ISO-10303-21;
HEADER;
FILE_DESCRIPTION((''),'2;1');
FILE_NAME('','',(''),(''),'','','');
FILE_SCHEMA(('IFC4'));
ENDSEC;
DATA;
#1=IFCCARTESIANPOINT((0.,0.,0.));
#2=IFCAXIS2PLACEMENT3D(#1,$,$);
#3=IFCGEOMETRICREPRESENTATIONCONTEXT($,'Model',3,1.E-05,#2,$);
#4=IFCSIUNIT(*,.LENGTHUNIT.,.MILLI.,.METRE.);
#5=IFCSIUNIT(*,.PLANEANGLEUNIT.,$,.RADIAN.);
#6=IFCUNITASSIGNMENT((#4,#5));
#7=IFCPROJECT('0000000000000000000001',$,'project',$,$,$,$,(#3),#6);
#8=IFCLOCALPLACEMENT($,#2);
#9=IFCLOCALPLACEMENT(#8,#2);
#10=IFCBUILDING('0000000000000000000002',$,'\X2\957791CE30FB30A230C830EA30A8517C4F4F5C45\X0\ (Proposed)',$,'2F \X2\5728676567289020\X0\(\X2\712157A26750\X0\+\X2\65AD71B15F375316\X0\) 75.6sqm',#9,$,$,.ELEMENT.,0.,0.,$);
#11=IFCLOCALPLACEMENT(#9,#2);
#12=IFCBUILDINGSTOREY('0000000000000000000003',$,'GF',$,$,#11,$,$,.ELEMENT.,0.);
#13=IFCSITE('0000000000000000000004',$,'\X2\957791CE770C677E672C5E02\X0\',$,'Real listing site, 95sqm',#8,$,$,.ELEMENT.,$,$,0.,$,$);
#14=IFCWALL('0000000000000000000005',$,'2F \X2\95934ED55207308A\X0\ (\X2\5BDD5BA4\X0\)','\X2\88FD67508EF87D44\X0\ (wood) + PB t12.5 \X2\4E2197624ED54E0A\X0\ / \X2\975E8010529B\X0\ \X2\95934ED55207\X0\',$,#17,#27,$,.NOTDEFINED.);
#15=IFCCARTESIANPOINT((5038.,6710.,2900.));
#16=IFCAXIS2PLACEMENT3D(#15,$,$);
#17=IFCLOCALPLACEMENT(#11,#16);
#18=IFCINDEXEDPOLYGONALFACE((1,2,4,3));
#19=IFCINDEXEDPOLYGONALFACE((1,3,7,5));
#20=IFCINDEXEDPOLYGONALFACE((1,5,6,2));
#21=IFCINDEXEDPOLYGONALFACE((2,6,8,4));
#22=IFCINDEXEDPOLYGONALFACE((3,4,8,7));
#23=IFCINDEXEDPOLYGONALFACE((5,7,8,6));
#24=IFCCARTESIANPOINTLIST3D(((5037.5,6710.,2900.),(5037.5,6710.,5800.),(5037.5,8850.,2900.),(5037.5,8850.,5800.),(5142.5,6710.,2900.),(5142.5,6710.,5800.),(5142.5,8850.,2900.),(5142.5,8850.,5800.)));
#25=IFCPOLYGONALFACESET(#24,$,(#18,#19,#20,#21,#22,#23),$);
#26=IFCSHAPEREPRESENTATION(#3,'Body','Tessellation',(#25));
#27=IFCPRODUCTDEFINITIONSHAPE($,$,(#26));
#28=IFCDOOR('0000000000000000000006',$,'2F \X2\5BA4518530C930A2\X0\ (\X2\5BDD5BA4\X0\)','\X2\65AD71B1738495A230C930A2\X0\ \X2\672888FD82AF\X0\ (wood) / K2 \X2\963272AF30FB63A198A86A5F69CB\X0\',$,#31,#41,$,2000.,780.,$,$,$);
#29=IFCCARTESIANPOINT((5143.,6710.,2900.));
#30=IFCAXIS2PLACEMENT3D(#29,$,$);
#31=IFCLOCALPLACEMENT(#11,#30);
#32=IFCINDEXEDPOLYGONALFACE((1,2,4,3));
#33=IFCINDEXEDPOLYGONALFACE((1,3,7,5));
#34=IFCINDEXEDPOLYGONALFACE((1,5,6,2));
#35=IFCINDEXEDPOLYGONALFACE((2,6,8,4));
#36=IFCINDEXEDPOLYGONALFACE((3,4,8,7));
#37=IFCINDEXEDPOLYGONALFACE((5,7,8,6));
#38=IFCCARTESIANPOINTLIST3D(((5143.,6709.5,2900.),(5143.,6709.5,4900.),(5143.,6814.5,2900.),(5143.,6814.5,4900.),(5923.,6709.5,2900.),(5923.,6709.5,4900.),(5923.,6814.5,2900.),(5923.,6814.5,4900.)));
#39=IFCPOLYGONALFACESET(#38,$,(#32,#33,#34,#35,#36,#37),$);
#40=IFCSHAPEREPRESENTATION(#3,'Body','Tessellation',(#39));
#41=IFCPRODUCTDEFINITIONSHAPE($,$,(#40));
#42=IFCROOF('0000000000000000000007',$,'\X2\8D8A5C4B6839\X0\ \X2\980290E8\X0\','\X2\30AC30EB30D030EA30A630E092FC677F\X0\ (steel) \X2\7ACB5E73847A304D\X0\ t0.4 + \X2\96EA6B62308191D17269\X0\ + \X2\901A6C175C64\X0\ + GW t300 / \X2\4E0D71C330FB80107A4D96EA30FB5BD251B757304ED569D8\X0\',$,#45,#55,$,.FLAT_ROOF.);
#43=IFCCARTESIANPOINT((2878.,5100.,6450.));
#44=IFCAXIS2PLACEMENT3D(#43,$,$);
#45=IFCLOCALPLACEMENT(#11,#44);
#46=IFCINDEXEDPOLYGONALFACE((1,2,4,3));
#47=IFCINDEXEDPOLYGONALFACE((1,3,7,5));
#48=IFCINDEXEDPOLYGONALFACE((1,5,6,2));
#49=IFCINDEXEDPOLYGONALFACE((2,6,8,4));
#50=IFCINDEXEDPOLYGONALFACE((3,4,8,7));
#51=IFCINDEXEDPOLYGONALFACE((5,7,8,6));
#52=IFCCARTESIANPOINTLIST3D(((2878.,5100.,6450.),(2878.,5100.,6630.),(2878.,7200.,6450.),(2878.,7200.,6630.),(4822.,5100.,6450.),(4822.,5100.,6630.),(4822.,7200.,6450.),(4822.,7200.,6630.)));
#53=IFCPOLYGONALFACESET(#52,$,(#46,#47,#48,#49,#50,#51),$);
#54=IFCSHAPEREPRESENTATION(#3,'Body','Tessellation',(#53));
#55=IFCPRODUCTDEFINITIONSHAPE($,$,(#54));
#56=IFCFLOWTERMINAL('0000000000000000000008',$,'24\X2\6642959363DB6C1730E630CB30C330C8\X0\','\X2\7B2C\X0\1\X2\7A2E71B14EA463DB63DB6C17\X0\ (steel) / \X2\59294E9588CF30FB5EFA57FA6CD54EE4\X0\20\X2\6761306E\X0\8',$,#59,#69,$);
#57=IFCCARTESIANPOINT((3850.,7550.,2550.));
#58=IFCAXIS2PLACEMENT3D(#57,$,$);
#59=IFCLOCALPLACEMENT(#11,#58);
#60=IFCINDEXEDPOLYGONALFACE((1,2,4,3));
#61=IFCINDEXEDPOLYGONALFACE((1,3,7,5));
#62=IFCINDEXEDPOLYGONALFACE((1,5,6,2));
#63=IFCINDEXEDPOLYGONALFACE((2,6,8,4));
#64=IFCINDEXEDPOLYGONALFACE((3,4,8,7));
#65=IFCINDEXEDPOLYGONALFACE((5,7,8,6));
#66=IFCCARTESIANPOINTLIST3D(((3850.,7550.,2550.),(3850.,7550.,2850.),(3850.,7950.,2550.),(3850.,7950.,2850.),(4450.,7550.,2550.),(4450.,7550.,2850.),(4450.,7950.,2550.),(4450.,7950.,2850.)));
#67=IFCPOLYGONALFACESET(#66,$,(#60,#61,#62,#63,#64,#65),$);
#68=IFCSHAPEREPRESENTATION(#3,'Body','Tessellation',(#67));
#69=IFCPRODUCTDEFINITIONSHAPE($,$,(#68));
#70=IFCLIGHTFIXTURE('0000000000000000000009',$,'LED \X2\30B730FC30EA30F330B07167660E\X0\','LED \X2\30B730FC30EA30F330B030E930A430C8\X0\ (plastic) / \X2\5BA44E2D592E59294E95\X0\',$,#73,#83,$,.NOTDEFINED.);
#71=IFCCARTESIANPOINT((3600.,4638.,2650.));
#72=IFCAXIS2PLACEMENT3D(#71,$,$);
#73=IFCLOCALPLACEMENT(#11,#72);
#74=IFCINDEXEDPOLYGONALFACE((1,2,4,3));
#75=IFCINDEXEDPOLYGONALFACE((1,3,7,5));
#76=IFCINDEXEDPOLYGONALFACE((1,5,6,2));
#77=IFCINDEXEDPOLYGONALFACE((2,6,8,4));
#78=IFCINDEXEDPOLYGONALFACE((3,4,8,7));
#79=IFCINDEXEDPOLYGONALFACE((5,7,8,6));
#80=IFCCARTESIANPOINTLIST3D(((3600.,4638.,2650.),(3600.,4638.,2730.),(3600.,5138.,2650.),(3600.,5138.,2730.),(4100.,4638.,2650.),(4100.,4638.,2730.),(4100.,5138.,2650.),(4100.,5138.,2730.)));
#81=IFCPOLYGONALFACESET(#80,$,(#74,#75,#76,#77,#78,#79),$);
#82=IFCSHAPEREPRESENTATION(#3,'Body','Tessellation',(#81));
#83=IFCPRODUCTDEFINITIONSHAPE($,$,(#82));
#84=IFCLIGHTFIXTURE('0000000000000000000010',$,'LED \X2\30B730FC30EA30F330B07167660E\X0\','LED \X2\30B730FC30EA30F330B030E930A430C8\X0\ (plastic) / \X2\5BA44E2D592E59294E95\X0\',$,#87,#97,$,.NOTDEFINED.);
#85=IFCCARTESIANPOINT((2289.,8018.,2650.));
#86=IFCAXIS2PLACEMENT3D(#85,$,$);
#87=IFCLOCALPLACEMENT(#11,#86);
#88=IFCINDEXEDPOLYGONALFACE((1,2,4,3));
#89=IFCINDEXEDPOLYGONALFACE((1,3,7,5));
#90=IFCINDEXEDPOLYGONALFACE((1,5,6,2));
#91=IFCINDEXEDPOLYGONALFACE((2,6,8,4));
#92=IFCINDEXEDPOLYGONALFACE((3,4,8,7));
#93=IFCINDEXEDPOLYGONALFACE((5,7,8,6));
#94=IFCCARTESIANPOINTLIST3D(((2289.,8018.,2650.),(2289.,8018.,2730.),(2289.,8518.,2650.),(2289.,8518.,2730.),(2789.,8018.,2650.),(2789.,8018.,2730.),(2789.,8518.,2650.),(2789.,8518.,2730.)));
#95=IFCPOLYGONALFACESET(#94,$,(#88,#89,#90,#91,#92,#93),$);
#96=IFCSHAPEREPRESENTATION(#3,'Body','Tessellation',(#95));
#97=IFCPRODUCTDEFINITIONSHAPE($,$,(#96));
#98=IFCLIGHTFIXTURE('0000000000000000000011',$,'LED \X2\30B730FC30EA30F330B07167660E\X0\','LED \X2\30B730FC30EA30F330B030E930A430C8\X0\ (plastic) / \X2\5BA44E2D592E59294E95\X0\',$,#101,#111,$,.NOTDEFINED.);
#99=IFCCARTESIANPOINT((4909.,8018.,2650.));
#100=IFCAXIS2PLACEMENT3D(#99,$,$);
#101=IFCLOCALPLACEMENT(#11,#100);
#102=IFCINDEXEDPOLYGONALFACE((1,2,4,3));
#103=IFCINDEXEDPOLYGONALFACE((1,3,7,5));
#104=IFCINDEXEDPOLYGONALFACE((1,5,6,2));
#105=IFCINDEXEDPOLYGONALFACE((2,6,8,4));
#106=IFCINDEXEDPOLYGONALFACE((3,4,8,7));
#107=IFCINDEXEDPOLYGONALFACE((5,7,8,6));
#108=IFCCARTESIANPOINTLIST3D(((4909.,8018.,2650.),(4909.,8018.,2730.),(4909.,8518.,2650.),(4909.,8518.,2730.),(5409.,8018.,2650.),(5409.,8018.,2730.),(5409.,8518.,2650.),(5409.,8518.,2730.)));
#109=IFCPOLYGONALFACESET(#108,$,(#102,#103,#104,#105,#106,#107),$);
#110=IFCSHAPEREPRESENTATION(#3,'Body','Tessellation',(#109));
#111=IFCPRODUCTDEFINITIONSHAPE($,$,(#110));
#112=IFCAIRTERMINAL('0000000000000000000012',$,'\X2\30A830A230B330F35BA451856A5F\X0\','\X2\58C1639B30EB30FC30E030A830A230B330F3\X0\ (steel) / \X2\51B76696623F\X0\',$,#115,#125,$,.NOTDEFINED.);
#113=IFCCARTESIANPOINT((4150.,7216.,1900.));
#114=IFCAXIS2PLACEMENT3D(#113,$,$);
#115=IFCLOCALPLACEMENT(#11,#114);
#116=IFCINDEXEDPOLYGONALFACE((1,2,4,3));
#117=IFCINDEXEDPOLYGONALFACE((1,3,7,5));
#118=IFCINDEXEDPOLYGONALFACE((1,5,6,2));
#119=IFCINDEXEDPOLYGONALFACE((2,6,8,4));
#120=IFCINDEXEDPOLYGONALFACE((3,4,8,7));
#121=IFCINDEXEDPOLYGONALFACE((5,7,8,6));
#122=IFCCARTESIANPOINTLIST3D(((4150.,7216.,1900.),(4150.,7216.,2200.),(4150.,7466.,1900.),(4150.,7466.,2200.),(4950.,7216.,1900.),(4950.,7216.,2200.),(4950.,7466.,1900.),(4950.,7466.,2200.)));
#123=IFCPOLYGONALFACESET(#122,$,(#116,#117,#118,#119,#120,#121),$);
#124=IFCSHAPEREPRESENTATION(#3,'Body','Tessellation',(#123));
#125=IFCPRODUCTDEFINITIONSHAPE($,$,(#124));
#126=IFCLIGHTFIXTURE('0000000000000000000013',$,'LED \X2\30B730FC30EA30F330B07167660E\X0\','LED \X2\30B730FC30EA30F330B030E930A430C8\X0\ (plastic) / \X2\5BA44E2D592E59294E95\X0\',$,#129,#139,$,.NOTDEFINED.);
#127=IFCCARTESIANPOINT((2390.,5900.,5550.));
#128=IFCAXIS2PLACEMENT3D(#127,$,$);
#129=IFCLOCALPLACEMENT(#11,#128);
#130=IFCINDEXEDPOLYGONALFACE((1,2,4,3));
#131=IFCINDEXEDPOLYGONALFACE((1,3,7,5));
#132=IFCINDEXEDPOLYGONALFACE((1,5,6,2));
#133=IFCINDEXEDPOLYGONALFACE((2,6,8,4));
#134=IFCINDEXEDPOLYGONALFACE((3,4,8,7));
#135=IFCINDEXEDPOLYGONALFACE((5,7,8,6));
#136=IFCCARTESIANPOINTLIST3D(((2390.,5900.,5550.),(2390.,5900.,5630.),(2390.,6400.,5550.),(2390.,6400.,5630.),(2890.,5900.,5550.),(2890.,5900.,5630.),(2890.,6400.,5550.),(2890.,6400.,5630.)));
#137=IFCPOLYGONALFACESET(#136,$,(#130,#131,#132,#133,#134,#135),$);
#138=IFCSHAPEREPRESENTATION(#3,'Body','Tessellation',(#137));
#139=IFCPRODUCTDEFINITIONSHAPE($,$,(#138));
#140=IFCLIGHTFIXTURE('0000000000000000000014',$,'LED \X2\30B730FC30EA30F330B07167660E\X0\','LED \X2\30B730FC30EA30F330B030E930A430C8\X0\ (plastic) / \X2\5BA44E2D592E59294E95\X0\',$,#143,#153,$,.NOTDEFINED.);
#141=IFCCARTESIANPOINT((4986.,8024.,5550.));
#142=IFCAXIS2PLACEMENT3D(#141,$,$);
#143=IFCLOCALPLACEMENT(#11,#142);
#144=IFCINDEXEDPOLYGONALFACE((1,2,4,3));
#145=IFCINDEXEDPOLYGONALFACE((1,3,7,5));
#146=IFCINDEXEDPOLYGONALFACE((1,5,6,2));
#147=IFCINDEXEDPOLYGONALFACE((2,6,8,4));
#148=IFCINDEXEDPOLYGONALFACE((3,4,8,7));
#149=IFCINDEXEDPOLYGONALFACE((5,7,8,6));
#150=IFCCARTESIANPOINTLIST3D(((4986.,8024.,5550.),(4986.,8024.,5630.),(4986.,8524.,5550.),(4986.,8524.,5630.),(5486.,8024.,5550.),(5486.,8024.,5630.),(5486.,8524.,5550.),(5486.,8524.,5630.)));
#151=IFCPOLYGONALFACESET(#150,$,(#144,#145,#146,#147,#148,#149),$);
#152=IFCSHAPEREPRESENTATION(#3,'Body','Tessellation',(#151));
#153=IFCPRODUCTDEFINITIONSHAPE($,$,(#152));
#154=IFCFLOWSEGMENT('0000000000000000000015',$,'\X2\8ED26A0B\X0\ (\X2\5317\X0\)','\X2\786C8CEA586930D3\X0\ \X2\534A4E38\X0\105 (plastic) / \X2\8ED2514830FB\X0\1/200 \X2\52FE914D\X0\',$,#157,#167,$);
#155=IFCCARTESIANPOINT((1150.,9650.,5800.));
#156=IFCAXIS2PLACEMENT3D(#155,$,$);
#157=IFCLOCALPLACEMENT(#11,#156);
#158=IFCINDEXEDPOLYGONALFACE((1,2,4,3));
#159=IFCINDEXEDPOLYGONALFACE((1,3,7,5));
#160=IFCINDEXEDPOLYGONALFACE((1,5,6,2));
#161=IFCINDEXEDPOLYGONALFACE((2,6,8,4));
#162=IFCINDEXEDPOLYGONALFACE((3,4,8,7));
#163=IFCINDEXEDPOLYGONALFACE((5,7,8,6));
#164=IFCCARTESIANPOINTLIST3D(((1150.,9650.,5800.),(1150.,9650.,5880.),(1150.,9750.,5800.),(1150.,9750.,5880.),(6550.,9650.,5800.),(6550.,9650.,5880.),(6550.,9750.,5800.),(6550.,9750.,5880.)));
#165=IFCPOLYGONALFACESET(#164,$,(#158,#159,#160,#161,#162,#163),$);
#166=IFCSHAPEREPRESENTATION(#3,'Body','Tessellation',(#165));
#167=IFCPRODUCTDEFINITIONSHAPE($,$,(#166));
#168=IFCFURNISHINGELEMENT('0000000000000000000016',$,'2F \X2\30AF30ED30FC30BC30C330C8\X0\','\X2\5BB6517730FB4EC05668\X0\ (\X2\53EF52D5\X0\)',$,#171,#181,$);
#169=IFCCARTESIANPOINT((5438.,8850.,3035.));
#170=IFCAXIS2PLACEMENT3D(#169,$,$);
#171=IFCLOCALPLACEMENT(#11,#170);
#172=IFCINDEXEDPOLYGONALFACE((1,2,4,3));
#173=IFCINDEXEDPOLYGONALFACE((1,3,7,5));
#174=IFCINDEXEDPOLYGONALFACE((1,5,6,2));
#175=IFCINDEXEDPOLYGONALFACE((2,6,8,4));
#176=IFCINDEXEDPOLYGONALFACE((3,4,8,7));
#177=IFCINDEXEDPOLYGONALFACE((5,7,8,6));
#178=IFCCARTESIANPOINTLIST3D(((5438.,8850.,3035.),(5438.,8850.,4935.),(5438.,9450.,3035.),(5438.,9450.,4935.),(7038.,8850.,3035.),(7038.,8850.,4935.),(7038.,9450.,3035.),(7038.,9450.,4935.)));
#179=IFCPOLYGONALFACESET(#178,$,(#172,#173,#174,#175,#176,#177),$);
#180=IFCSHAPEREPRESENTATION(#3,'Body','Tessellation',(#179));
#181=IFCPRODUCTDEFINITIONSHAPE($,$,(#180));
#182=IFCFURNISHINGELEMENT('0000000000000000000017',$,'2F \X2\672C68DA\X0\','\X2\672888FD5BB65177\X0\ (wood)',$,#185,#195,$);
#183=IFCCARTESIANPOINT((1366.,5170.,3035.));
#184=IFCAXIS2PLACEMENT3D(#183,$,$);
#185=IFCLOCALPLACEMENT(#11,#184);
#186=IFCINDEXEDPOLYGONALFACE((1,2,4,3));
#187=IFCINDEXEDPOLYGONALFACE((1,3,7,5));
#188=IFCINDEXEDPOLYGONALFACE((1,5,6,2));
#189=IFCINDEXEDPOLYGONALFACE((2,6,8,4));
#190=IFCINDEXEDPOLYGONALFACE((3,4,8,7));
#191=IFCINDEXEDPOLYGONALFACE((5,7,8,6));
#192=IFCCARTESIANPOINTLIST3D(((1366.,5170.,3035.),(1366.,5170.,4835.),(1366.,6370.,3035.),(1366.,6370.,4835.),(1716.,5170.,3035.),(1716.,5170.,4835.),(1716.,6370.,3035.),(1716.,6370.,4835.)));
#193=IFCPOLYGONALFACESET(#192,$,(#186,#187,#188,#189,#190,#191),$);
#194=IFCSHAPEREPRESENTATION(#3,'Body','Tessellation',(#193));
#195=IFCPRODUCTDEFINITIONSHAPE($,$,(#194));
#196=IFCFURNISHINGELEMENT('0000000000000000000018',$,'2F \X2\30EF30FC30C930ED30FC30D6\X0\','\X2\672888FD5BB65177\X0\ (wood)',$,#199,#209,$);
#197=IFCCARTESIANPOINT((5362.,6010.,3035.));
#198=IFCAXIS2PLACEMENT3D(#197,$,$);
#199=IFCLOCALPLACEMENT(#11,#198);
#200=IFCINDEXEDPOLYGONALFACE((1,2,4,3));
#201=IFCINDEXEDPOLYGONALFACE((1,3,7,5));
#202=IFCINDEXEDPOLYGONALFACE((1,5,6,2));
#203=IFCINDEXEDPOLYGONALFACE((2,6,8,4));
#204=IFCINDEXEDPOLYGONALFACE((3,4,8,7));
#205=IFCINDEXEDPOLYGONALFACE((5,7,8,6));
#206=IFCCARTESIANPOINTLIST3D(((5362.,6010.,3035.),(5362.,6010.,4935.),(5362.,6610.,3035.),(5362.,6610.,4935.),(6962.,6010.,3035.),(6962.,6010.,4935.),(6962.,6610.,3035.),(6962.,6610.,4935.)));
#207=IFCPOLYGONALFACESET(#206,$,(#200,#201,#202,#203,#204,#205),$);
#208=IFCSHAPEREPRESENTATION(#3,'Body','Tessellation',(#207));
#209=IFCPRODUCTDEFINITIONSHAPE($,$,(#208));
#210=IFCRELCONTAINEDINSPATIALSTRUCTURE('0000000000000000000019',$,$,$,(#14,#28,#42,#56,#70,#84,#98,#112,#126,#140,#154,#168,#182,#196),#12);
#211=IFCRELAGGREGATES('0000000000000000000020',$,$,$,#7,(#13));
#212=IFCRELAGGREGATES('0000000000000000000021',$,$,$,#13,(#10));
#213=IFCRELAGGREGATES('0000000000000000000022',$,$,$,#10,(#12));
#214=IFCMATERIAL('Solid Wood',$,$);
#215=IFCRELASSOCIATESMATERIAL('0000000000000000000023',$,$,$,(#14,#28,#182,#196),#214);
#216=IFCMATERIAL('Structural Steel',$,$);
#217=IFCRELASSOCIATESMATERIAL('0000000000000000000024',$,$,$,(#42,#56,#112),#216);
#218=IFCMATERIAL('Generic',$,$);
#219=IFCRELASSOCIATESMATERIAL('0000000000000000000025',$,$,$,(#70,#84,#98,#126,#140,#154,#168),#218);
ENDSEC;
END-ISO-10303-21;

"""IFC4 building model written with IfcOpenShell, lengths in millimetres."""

from ifc_helpers import new_model, si_unit, frame, frame_2d, origin, place, context, project, spatial, rectangle, extrude, material, element, save


model = new_model("IFC4")

# Units and contexts
model_context = context("Model", 3, precision=1e-05, world=origin())
ifc_project = project(units=[si_unit("LENGTHUNIT", "METRE", prefix="MILLI"), si_unit("PLANEANGLEUNIT", "RADIAN")], contexts=[model_context])

# Site, building, storey
site_placement = place(None, origin())
site = spatial("IfcSite", under=ifc_project, at=site_placement, Name="長野県松本市", ObjectType="Real listing site, 95sqm", CompositionType="ELEMENT", RefElevation=0.0)
building_placement = place(site_placement, origin())
building = spatial("IfcBuilding", under=site, at=building_placement, Name="長野・アトリエ兼住居 (Proposed)", ObjectType="2F 在来木造(無垢材+断熱強化) 75.6sqm", CompositionType="ELEMENT", ElevationOfRefHeight=0.0, ElevationOfTerrain=0.0)
storey_placement = place(building_placement, origin())
storey = spatial("IfcBuildingStorey", under=building, at=storey_placement, Name="GF", CompositionType="ELEMENT", Elevation=0.0)

# Shared definitions
ifc_material_1 = material(Name="Solid Wood")

# Wall
wall_1_placement = place(storey_placement, frame((5038.0, 6710.0, 2900.0)))
element("IfcWall", 1, at=wall_1_placement, inside=storey, material=ifc_material_1, Name="2F 間仕切り (寝室)", Description="製材軸組 (wood) + PB t12.5 両面仕上 / 非耐力 間仕切", PredefinedType="NOTDEFINED", context=model_context, shape_type="SweptSolid", body=[
    extrude(rectangle(XDim=105.0, YDim=2140.0, at=frame_2d((52.0, 1070.0))), frame((5038.0, 6710.0, 2900.0)), (0.0, 0.0, 1.0), 2900.0),
])

# Door
door_placement = place(storey_placement, frame((5143.0, 6710.0, 2900.0)))
element("IfcDoor", 2, at=door_placement, inside=storey, material=ifc_material_1, Name="2F 室内ドア (寝室)", Description="断熱玄関ドア 木製芯 (wood) / K2 防犯・採風機構", OverallHeight=2000.0, OverallWidth=780.0, context=model_context, shape_type="SweptSolid", body=[
    extrude(rectangle(XDim=780.0, YDim=105.0, at=frame_2d((390.0, 52.0))), frame((5143.0, 6710.0, 2900.0)), (0.0, 0.0, 1.0), 2000.0),
])

# Roof
ifc_material_2 = material(Name="Structural Steel")
roof_placement = place(storey_placement, frame((2878.0, 5100.0, 6450.0)))
element("IfcRoof", 3, at=roof_placement, inside=storey, material=ifc_material_2, Name="越屋根 頂部", Description="ガルバリウム鋼板 (steel) 立平葺き t0.4 + 雪止め金物 + 通気層 + GW t300 / 不燃・耐積雪・寒冷地仕様", PredefinedType="FLAT_ROOF", context=model_context, shape_type="SweptSolid", body=[
    extrude(rectangle(XDim=1944.0, YDim=2100.0, at=frame_2d((972.0, 1050.0))), frame((2878.0, 5100.0, 6450.0)), (0.0, 0.0, 1.0), 180.0),
])

# Flow terminal
flow_terminal_placement = place(storey_placement, frame((3850.0, 7550.0, 2550.0)))
element("IfcFlowTerminal", 4, at=flow_terminal_placement, inside=storey, material=ifc_material_2, Name="24時間換気ユニット", Description="第1種熱交換換気 (steel) / 天井裏・建基法令20条の8", context=model_context, shape_type="SweptSolid", body=[
    extrude(rectangle(XDim=600.0, YDim=400.0, at=frame_2d((300.0, 200.0))), frame((3850.0, 7550.0, 2550.0)), (0.0, 0.0, 1.0), 300.0),
])

# Light fixtures
ifc_material_3 = material(Name="Generic")
light_fixture_1_placement = place(storey_placement, frame((3600.0, 4638.0, 2650.0)))
element("IfcLightFixture", 5, at=light_fixture_1_placement, inside=storey, material=ifc_material_3, Name="LED シーリング照明", Description="LED シーリングライト (plastic) / 室中央天井", PredefinedType="NOTDEFINED", context=model_context, shape_type="SweptSolid", body=[
    extrude(rectangle(XDim=500.0, YDim=500.0, at=frame_2d((250.0, 250.0))), frame((3600.0, 4638.0, 2650.0)), (0.0, 0.0, 1.0), 80.0),
])
light_fixture_2_placement = place(storey_placement, frame((2289.0, 8018.0, 2650.0)))
element("IfcLightFixture", 6, at=light_fixture_2_placement, inside=storey, material=ifc_material_3, Name="LED シーリング照明", Description="LED シーリングライト (plastic) / 室中央天井", PredefinedType="NOTDEFINED", context=model_context, shape_type="SweptSolid", body=[
    extrude(rectangle(XDim=500.0, YDim=500.0, at=frame_2d((250.0, 250.0))), frame((2289.0, 8018.0, 2650.0)), (0.0, 0.0, 1.0), 80.0),
])
light_fixture_3_placement = place(storey_placement, frame((4909.0, 8018.0, 2650.0)))
element("IfcLightFixture", 7, at=light_fixture_3_placement, inside=storey, material=ifc_material_3, Name="LED シーリング照明", Description="LED シーリングライト (plastic) / 室中央天井", PredefinedType="NOTDEFINED", context=model_context, shape_type="SweptSolid", body=[
    extrude(rectangle(XDim=500.0, YDim=500.0, at=frame_2d((250.0, 250.0))), frame((4909.0, 8018.0, 2650.0)), (0.0, 0.0, 1.0), 80.0),
])

# Air terminal
air_terminal_placement = place(storey_placement, frame((4150.0, 7216.0, 1900.0)))
element("IfcAirTerminal", 8, at=air_terminal_placement, inside=storey, material=ifc_material_2, Name="エアコン室内機", Description="壁掛ルームエアコン (steel) / 冷暖房", PredefinedType="NOTDEFINED", context=model_context, shape_type="SweptSolid", body=[
    extrude(rectangle(XDim=800.0, YDim=250.0, at=frame_2d((400.0, 125.0))), frame((4150.0, 7216.0, 1900.0)), (0.0, 0.0, 1.0), 300.0),
])

# Light fixtures
light_fixture_4_placement = place(storey_placement, frame((2390.0, 5900.0, 5550.0)))
element("IfcLightFixture", 9, at=light_fixture_4_placement, inside=storey, material=ifc_material_3, Name="LED シーリング照明", Description="LED シーリングライト (plastic) / 室中央天井", PredefinedType="NOTDEFINED", context=model_context, shape_type="SweptSolid", body=[
    extrude(rectangle(XDim=500.0, YDim=500.0, at=frame_2d((250.0, 250.0))), frame((2390.0, 5900.0, 5550.0)), (0.0, 0.0, 1.0), 80.0),
])
light_fixture_5_placement = place(storey_placement, frame((4986.0, 8024.0, 5550.0)))
element("IfcLightFixture", 10, at=light_fixture_5_placement, inside=storey, material=ifc_material_3, Name="LED シーリング照明", Description="LED シーリングライト (plastic) / 室中央天井", PredefinedType="NOTDEFINED", context=model_context, shape_type="SweptSolid", body=[
    extrude(rectangle(XDim=500.0, YDim=500.0, at=frame_2d((250.0, 250.0))), frame((4986.0, 8024.0, 5550.0)), (0.0, 0.0, 1.0), 80.0),
])

# Flow segment
flow_segment_placement = place(storey_placement, frame((1150.0, 9650.0, 5800.0)))
element("IfcFlowSegment", 11, at=flow_segment_placement, inside=storey, material=ifc_material_3, Name="軒樋 (北)", Description="硬質塩ビ 半丸105 (plastic) / 軒先・1/200 勾配", context=model_context, shape_type="SweptSolid", body=[
    extrude(rectangle(XDim=5400.0, YDim=100.0, at=frame_2d((2700.0, 50.0))), frame((1150.0, 9650.0, 5800.0)), (0.0, 0.0, 1.0), 80.0),
])

# Furnishing elements
furnishing_1_placement = place(storey_placement, frame((5438.0, 8850.0, 3035.0)))
element("IfcFurnishingElement", 12, at=furnishing_1_placement, inside=storey, material=ifc_material_3, Name="2F クローゼット", Description="家具・什器 (可動)", context=model_context, shape_type="SweptSolid", body=[
    extrude(rectangle(XDim=1600.0, YDim=600.0, at=frame_2d((800.0, 300.0))), frame((5438.0, 8850.0, 3035.0)), (0.0, 0.0, 1.0), 1900.0),
])
furnishing_2_placement = place(storey_placement, frame((1366.0, 5170.0, 3035.0)))
element("IfcFurnishingElement", 13, at=furnishing_2_placement, inside=storey, material=ifc_material_1, Name="2F 本棚", Description="木製家具 (wood)", context=model_context, shape_type="SweptSolid", body=[
    extrude(rectangle(XDim=350.0, YDim=1200.0, at=frame_2d((175.0, 600.0))), frame((1366.0, 5170.0, 3035.0)), (0.0, 0.0, 1.0), 1800.0),
])
furnishing_3_placement = place(storey_placement, frame((5362.0, 6010.0, 3035.0)))
element("IfcFurnishingElement", 14, at=furnishing_3_placement, inside=storey, material=ifc_material_1, Name="2F ワードローブ", Description="木製家具 (wood)", context=model_context, shape_type="SweptSolid", body=[
    extrude(rectangle(XDim=1600.0, YDim=600.0, at=frame_2d((800.0, 300.0))), frame((5362.0, 6010.0, 3035.0)), (0.0, 0.0, 1.0), 1900.0),
])

save(model, "model.ifc")
